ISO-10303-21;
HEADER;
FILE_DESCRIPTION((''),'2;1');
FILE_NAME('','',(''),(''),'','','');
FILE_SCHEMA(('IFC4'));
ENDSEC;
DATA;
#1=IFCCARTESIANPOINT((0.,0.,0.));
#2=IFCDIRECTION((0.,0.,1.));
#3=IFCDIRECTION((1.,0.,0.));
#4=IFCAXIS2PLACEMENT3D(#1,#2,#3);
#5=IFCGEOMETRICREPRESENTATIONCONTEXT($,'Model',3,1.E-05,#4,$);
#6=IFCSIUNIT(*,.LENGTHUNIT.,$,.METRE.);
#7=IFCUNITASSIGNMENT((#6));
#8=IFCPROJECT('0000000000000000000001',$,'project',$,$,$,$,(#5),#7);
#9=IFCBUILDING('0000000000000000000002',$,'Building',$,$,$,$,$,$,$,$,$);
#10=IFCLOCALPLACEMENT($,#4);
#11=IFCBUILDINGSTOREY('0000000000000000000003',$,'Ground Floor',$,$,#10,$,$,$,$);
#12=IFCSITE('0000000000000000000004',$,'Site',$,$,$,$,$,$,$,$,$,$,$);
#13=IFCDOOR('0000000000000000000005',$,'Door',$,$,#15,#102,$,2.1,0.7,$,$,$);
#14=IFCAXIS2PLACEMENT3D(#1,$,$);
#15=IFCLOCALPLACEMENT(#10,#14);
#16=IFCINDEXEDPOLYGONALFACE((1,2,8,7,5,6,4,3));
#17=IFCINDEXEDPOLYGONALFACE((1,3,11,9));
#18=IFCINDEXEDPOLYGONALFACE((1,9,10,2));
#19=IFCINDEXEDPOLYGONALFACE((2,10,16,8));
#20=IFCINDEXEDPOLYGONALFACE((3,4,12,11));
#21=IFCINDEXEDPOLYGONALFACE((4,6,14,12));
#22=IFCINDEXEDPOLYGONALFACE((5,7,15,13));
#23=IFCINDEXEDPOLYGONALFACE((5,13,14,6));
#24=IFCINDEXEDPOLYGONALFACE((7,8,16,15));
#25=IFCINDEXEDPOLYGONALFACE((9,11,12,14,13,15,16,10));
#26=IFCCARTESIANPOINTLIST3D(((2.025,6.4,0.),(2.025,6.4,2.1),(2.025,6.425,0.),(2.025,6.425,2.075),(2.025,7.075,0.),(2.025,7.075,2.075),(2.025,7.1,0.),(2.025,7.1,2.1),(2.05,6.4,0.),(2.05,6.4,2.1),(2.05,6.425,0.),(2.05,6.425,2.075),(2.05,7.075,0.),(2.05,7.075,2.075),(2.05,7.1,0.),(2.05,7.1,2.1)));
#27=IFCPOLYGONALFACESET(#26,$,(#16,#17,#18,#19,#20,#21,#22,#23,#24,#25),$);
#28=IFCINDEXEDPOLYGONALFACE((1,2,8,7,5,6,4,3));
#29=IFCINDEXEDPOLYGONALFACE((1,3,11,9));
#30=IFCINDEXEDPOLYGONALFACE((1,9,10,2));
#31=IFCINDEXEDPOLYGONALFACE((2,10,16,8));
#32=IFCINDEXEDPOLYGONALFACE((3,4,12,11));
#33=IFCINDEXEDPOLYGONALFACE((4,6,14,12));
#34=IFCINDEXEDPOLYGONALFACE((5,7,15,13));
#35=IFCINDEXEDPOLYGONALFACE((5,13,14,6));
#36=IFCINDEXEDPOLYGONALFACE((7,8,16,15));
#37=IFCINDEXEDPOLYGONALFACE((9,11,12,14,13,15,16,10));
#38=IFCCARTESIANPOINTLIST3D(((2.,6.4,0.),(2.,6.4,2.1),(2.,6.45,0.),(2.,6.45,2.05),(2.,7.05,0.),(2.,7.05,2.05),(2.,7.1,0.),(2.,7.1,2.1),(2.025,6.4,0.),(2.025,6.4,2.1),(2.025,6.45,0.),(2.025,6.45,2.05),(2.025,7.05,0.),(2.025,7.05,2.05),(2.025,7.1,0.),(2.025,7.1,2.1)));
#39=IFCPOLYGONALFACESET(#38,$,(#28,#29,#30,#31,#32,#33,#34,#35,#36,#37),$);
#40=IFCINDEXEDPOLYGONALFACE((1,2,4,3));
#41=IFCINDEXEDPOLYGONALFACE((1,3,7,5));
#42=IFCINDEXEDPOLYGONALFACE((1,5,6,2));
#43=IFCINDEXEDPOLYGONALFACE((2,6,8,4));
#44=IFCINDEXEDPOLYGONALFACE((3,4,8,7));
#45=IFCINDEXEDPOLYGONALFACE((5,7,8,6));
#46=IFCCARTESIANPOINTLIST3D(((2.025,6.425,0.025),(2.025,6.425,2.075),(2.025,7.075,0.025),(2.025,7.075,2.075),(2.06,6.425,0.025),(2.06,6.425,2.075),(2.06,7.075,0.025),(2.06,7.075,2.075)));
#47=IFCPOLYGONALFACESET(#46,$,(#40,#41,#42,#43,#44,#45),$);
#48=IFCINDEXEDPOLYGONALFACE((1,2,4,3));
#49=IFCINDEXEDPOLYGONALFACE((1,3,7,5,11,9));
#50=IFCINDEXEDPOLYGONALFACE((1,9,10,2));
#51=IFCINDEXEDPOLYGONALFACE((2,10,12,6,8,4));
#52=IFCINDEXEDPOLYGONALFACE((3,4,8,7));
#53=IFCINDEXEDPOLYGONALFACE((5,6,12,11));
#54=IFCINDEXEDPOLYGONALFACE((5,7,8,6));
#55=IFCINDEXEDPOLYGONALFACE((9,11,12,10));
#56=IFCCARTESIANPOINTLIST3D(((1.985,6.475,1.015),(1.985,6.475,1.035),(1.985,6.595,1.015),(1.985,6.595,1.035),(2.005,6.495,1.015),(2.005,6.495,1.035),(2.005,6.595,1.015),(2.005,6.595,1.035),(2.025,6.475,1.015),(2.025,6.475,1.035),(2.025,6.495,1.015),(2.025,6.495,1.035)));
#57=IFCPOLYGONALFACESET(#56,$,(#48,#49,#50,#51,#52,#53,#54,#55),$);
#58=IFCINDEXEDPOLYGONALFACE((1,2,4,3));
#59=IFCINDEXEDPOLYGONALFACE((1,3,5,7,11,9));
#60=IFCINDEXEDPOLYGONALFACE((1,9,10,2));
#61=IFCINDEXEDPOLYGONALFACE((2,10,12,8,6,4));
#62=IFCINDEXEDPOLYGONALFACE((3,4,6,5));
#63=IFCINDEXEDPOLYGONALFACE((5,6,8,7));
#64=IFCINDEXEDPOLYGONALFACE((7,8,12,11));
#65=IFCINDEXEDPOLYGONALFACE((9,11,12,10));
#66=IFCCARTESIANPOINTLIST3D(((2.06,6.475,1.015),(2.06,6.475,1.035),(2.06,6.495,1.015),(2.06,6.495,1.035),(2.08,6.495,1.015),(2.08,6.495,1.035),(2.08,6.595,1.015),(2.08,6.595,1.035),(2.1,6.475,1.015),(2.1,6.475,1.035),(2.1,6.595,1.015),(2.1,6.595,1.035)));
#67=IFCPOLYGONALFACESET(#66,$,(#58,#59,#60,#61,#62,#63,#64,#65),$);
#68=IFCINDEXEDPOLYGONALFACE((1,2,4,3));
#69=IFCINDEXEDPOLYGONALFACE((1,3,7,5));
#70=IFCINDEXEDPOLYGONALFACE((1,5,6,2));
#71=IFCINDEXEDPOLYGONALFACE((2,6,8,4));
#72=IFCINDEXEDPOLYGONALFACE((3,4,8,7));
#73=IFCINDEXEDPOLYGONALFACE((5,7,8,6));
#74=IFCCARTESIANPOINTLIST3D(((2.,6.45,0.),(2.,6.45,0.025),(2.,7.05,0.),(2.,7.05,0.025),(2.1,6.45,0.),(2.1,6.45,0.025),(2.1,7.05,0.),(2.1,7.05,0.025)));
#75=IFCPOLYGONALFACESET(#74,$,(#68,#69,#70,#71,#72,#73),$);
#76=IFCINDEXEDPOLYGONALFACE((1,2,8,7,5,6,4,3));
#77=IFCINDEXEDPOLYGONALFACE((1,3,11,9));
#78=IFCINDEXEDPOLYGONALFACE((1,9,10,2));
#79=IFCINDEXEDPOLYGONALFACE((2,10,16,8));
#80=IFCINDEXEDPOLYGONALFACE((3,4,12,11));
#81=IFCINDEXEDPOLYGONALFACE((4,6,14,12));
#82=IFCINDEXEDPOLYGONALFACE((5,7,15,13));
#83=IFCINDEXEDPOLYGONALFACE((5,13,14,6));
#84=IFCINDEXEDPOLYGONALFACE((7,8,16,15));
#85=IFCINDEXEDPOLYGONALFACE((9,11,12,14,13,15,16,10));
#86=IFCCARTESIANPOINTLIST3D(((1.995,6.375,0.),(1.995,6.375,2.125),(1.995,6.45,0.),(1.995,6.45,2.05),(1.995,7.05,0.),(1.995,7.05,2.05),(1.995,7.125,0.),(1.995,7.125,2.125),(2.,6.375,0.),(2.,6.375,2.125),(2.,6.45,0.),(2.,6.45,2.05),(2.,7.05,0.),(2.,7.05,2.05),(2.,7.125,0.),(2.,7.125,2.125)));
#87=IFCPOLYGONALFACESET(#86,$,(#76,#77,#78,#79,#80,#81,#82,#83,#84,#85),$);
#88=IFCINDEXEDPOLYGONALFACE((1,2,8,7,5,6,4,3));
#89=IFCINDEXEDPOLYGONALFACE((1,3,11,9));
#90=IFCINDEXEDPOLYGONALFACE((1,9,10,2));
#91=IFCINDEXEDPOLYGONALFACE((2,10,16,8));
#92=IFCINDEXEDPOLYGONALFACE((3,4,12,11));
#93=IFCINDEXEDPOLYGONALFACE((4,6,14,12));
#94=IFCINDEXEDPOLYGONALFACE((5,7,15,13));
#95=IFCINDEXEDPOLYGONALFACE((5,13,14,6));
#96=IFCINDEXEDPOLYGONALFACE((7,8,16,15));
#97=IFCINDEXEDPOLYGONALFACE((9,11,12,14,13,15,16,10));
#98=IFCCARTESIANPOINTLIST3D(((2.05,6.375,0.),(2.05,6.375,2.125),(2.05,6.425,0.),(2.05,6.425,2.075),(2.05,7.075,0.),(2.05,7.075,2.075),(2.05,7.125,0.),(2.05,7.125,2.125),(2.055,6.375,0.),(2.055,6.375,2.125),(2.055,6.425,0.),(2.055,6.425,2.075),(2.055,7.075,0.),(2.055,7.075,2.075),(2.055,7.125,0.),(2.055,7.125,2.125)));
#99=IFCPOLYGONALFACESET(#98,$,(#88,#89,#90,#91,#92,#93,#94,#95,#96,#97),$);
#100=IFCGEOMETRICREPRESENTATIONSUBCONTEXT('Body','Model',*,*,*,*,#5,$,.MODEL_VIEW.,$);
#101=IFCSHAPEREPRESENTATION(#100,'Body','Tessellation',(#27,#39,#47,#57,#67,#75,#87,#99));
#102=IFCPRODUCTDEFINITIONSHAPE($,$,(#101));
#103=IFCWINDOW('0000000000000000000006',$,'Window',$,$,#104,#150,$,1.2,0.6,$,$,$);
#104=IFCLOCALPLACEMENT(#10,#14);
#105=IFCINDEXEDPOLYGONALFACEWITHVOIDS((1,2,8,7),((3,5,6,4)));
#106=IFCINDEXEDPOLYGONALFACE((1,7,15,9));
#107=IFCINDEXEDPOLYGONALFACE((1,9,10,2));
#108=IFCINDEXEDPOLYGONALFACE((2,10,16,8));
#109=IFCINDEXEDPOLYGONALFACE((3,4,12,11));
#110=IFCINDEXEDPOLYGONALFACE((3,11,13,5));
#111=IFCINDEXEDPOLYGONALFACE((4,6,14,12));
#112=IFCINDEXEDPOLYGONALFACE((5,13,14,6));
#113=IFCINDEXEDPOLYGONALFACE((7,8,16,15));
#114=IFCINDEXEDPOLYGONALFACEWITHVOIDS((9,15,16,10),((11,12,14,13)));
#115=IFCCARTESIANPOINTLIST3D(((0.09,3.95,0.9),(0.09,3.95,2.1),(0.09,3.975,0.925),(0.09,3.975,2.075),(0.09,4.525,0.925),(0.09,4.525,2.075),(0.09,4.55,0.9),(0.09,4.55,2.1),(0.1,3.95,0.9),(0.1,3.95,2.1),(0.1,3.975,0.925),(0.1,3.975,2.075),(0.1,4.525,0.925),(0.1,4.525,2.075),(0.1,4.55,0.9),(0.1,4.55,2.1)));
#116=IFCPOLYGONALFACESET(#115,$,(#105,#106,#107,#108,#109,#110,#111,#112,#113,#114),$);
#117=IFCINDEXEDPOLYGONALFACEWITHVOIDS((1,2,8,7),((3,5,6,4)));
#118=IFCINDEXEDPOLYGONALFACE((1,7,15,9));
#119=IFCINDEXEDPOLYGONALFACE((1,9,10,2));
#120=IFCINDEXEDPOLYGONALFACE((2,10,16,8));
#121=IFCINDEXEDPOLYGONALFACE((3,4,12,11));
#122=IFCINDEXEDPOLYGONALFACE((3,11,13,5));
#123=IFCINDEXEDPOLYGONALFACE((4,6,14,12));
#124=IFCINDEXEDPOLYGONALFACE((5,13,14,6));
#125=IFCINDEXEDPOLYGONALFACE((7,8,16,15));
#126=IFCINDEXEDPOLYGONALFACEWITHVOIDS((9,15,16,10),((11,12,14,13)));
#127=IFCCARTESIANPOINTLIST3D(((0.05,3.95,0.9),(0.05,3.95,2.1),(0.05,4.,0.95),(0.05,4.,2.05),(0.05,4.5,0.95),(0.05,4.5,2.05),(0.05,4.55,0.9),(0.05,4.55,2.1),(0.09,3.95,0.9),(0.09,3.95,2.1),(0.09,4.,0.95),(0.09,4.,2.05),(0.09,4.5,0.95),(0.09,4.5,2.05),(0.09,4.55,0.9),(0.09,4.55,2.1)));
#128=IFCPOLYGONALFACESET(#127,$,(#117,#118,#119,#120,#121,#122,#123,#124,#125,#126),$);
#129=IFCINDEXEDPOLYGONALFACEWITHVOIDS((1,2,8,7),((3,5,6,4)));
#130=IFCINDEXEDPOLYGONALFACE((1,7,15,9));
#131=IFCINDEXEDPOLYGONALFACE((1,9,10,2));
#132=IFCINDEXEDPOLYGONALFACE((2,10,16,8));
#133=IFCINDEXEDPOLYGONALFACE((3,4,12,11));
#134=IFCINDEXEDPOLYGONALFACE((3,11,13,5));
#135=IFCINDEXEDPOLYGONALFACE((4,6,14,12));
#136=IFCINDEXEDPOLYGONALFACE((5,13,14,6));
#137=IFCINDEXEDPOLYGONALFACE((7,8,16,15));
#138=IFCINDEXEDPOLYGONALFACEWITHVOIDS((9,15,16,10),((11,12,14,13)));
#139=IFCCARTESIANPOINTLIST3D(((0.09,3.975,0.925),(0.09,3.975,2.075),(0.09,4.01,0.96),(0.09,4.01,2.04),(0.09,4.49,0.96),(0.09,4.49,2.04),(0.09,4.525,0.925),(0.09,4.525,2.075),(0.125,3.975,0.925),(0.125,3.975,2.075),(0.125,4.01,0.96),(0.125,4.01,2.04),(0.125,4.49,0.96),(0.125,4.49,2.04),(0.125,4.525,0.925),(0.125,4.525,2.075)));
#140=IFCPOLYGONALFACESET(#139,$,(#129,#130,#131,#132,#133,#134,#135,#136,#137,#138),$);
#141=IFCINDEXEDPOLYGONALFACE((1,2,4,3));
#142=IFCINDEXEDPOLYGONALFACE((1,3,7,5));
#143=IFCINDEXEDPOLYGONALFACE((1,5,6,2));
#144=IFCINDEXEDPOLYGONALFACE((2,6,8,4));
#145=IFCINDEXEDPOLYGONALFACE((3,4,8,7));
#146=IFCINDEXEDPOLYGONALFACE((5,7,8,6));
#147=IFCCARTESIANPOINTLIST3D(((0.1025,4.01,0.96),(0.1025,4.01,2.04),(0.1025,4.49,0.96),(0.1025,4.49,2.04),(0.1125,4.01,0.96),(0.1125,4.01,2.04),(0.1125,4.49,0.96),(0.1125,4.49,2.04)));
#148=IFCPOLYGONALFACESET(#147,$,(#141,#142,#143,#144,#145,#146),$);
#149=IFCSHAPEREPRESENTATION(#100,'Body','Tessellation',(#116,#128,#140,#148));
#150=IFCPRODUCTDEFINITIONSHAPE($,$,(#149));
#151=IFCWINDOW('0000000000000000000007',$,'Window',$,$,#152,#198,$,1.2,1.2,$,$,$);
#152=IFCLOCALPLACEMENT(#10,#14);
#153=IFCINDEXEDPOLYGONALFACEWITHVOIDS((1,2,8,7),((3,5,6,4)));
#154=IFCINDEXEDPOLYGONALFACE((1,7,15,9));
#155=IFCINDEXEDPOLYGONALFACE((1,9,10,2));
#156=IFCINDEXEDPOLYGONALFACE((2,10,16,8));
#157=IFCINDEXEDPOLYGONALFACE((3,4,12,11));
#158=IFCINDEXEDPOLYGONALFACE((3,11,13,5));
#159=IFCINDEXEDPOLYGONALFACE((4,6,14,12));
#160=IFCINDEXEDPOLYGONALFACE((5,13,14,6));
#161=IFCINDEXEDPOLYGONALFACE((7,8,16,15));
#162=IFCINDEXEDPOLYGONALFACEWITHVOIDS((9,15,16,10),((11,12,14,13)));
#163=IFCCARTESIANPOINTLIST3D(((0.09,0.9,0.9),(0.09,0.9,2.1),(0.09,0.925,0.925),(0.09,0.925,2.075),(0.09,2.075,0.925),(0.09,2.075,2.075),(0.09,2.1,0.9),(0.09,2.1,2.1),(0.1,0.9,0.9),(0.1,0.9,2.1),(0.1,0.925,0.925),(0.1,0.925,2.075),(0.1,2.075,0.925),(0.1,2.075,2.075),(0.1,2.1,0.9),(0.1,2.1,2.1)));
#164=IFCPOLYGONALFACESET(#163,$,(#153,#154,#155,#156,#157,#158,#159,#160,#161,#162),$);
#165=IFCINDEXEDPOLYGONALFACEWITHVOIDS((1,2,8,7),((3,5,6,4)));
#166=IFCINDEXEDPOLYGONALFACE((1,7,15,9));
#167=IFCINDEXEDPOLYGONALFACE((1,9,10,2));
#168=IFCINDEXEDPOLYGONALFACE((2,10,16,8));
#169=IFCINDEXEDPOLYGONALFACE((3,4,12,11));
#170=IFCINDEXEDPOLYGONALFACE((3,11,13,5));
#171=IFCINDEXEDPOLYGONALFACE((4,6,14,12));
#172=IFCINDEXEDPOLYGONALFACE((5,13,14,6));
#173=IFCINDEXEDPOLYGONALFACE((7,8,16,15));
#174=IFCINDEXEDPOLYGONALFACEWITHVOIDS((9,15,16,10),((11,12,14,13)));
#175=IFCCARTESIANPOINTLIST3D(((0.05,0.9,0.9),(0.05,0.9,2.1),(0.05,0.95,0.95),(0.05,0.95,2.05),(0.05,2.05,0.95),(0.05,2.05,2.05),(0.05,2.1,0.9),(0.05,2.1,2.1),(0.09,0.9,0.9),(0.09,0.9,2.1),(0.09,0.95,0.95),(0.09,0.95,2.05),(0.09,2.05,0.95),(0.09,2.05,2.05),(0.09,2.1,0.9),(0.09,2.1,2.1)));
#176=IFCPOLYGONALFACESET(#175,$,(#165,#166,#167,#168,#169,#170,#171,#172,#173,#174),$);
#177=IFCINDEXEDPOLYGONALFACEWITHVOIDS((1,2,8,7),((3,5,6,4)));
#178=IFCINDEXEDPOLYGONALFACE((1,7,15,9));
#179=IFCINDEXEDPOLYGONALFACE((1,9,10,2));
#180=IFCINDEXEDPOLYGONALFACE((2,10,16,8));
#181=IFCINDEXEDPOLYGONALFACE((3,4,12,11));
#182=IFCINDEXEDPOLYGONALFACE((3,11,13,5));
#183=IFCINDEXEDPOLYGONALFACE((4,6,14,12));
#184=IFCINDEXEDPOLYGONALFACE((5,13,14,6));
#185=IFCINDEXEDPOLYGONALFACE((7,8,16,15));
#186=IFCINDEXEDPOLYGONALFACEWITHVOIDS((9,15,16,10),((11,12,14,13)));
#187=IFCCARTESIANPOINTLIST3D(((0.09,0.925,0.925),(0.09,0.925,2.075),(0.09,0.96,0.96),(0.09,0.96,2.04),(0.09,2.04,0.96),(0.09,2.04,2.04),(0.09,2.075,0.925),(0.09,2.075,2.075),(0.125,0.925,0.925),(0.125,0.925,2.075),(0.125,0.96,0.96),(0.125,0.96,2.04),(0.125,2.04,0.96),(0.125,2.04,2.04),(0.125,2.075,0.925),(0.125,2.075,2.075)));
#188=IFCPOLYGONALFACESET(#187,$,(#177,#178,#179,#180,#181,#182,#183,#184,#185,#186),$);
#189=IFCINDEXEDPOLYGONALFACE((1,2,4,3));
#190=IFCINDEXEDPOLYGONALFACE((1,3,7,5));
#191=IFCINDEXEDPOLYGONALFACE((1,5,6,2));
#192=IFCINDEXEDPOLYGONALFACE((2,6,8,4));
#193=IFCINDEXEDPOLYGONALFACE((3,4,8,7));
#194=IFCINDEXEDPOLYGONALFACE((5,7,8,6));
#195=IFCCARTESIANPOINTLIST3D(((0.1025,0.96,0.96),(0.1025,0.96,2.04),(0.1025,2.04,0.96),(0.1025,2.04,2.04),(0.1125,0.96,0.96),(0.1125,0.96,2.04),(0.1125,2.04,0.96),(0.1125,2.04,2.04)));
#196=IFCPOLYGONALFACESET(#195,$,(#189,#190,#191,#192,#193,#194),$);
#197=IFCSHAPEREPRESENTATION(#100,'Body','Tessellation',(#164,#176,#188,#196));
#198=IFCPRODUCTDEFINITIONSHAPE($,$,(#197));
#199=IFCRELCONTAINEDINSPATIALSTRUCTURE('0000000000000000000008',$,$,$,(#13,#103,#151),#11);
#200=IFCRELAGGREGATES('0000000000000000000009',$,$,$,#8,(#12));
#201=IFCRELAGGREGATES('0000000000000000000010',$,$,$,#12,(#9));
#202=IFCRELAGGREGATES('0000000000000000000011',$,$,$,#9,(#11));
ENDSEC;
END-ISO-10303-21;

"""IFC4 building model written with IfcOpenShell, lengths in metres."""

from ifc_helpers import new_model, si_unit, frame, origin_with_axes, place, context, subcontext, project, spatial, line, indexed_curve, outline, extrude, element, save


model = new_model("IFC4")

# Units and contexts
model_context = context("Model", 3, precision=1e-05, world=origin_with_axes())
body_context = subcontext(model_context, "Body", "Model", "MODEL_VIEW")
ifc_project = project(units=[si_unit("LENGTHUNIT", "METRE")], contexts=[model_context])

# Site, building, storey
site = spatial("IfcSite", under=ifc_project, Name="Site")
building = spatial("IfcBuilding", under=site, Name="Building")
storey_placement = place(None, origin_with_axes())
storey = spatial("IfcBuildingStorey", under=building, at=storey_placement, Name="Ground Floor")

# Door
door_1_placement = place(storey_placement, frame((2.0, 7.1, 0.0), z_axis=(0.0, 0.0, 1.0), x_axis=(0.0, -1.0, 0.0)))
element("IfcDoor", 1, at=door_1_placement, inside=storey, Name="Door", OverallHeight=2.1, OverallWidth=0.7, context=body_context, shape_type="SweptSolid", body=[
    extrude(outline(indexed_curve([(0.0, 0.0), (0.0, 2.1), (0.7, 2.1), (0.7, 0.0), (0.675, 0.0), (0.675, 2.075), (0.025, 2.075), (0.025, 0.0)], segments=[line(1, 2, 3, 4, 5, 6, 7, 8, 1)])), frame((0.0, 0.025, 0.0), z_axis=(0.0, -1.0, 0.0), x_axis=(1.0, 0.0, 0.0)), (0.0, 0.0, -1.0), 0.025),
    extrude(outline(indexed_curve([(0.0, 0.0), (0.0, 2.1), (0.7, 2.1), (0.7, 0.0), (0.65, 0.0), (0.65, 2.05), (0.05, 2.05), (0.05, 0.0)], segments=[line(1, 2, 3, 4, 5, 6, 7, 8, 1)])), frame((0.0, 0.0, 0.0), z_axis=(0.0, -1.0, 0.0), x_axis=(1.0, 0.0, 0.0)), (0.0, 0.0, -1.0), 0.025),
    extrude(outline(indexed_curve([(0.0, 0.0), (0.65, 0.0), (0.65, 0.035), (0.0, 0.035)], segments=[line(1, 2, 3, 4, 1)])), frame((0.025, 0.025, 0.025), z_axis=(0.0, 0.0, 1.0), x_axis=(1.0, 0.0, 0.0)), (0.0, 0.0, 1.0), 2.05),
    extrude(outline(indexed_curve([(0.0, 0.0), (0.0, -0.04), (-0.12, -0.04), (-0.12, -0.02), (-0.02, -0.02), (-0.02, 0.0)], segments=[line(1, 2, 3, 4, 5, 6, 1)])), frame((0.625, 0.025, 1.015), z_axis=(0.0, 0.0, 1.0), x_axis=(1.0, 0.0, 0.0)), (0.0, 0.0, 1.0), 0.02),
    extrude(outline(indexed_curve([(0.0, 0.0), (0.0, 0.04), (-0.12, 0.04), (-0.12, 0.02), (-0.02, 0.02), (-0.02, 0.0)], segments=[line(1, 2, 3, 4, 5, 6, 1)])), frame((0.625, 0.06, 1.015), z_axis=(0.0, 0.0, 1.0), x_axis=(1.0, 0.0, 0.0)), (0.0, 0.0, 1.0), 0.02),
    extrude(outline(indexed_curve([(0.0, 0.0), (0.6, 0.0), (0.6, 0.1), (0.0, 0.1)], segments=[line(1, 2, 3, 4, 1)])), frame((0.05, 0.0, 0.0), z_axis=(0.0, 0.0, 1.0), x_axis=(1.0, 0.0, 0.0)), (0.0, 0.0, 1.0), 0.025),
    extrude(outline(indexed_curve([(0.0, 0.0), (0.0, 2.125), (0.75, 2.125), (0.75, 0.0), (0.675, 0.0), (0.675, 2.05), (0.075, 2.05), (0.075, 0.0)], segments=[line(1, 2, 3, 4, 5, 6, 7, 8, 1)])), frame((-0.025, -0.005, 0.0), z_axis=(0.0, -1.0, 0.0), x_axis=(1.0, 0.0, 0.0)), (0.0, 0.0, -1.0), 0.005),
    extrude(outline(indexed_curve([(0.0, 0.0), (0.0, 2.125), (0.75, 2.125), (0.75, 0.0), (0.7, 0.0), (0.7, 2.075), (0.05, 2.075), (0.05, 0.0)], segments=[line(1, 2, 3, 4, 5, 6, 7, 8, 1)])), frame((-0.025, 0.05, 0.0), z_axis=(0.0, -1.0, 0.0), x_axis=(1.0, 0.0, 0.0)), (0.0, 0.0, -1.0), 0.005),
])

# Windows
window_1_placement = place(storey_placement, frame((0.0, 4.55, 0.9), z_axis=(0.0, 0.0, 1.0), x_axis=(0.0, -1.0, 0.0)))
element("IfcWindow", 2, at=window_1_placement, inside=storey, Name="Window", OverallHeight=1.2, OverallWidth=0.6, context=body_context, shape_type="SweptSolid", body=[
    extrude(outline(indexed_curve([(0.0, 0.0), (0.6, 0.0), (0.6, 1.2), (0.0, 1.2)], segments=[line(1, 2, 3, 4, 1)]), holes=[indexed_curve([(0.025, 0.025), (0.575, 0.025), (0.575, 1.175), (0.025, 1.175)], segments=[line(1, 2, 3, 4, 1)])]), frame((0.0, 0.09, 0.0), z_axis=(0.0, -1.0, 0.0), x_axis=(1.0, 0.0, 0.0)), (0.0, 0.0, -1.0), 0.01),
    extrude(outline(indexed_curve([(0.0, 0.0), (0.6, 0.0), (0.6, 1.2), (0.0, 1.2)], segments=[line(1, 2, 3, 4, 1)]), holes=[indexed_curve([(0.05, 0.05), (0.55, 0.05), (0.55, 1.15), (0.05, 1.15)], segments=[line(1, 2, 3, 4, 1)])]), frame((0.0, 0.05, 0.0), z_axis=(0.0, -1.0, 0.0), x_axis=(1.0, 0.0, 0.0)), (0.0, 0.0, -1.0), 0.04),
    extrude(outline(indexed_curve([(0.0, 0.0), (0.55, 0.0), (0.55, 1.15), (0.0, 1.15)], segments=[line(1, 2, 3, 4, 1)]), holes=[indexed_curve([(0.035, 0.035), (0.515, 0.035), (0.515, 1.115), (0.035, 1.115)], segments=[line(1, 2, 3, 4, 1)])]), frame((0.025, 0.09, 0.025), z_axis=(0.0, -1.0, 0.0), x_axis=(1.0, 0.0, 0.0)), (0.0, 0.0, -1.0), 0.035),
    extrude(outline(indexed_curve([(0.035, 0.035), (0.515, 0.035), (0.515, 1.115), (0.035, 1.115)], segments=[line(1, 2, 3, 4, 1)])), frame((0.025, 0.1025, 0.025), z_axis=(0.0, -1.0, 0.0), x_axis=(1.0, 0.0, 0.0)), (0.0, 0.0, -1.0), 0.01),
])
window_2_placement = place(storey_placement, frame((0.0, 2.1, 0.9), z_axis=(0.0, 0.0, 1.0), x_axis=(0.0, -1.0, 0.0)))
element("IfcWindow", 3, at=window_2_placement, inside=storey, Name="Window", OverallHeight=1.2, OverallWidth=1.2, context=body_context, shape_type="SweptSolid", body=[
    extrude(outline(indexed_curve([(0.0, 0.0), (1.2, 0.0), (1.2, 1.2), (0.0, 1.2)], segments=[line(1, 2, 3, 4, 1)]), holes=[indexed_curve([(0.025, 0.025), (1.175, 0.025), (1.175, 1.175), (0.025, 1.175)], segments=[line(1, 2, 3, 4, 1)])]), frame((0.0, 0.09, 0.0), z_axis=(0.0, -1.0, 0.0), x_axis=(1.0, 0.0, 0.0)), (0.0, 0.0, -1.0), 0.01),
    extrude(outline(indexed_curve([(0.0, 0.0), (1.2, 0.0), (1.2, 1.2), (0.0, 1.2)], segments=[line(1, 2, 3, 4, 1)]), holes=[indexed_curve([(0.05, 0.05), (1.15, 0.05), (1.15, 1.15), (0.05, 1.15)], segments=[line(1, 2, 3, 4, 1)])]), frame((0.0, 0.05, 0.0), z_axis=(0.0, -1.0, 0.0), x_axis=(1.0, 0.0, 0.0)), (0.0, 0.0, -1.0), 0.04),
    extrude(outline(indexed_curve([(0.0, 0.0), (1.15, 0.0), (1.15, 1.15), (0.0, 1.15)], segments=[line(1, 2, 3, 4, 1)]), holes=[indexed_curve([(0.035, 0.035), (1.115, 0.035), (1.115, 1.115), (0.035, 1.115)], segments=[line(1, 2, 3, 4, 1)])]), frame((0.025, 0.09, 0.025), z_axis=(0.0, -1.0, 0.0), x_axis=(1.0, 0.0, 0.0)), (0.0, 0.0, -1.0), 0.035),
    extrude(outline(indexed_curve([(0.035, 0.035), (1.115, 0.035), (1.115, 1.115), (0.035, 1.115)], segments=[line(1, 2, 3, 4, 1)])), frame((0.025, 0.1025, 0.025), z_axis=(0.0, -1.0, 0.0), x_axis=(1.0, 0.0, 0.0)), (0.0, 0.0, -1.0), 0.01),
])

save(model, "model.ifc")
